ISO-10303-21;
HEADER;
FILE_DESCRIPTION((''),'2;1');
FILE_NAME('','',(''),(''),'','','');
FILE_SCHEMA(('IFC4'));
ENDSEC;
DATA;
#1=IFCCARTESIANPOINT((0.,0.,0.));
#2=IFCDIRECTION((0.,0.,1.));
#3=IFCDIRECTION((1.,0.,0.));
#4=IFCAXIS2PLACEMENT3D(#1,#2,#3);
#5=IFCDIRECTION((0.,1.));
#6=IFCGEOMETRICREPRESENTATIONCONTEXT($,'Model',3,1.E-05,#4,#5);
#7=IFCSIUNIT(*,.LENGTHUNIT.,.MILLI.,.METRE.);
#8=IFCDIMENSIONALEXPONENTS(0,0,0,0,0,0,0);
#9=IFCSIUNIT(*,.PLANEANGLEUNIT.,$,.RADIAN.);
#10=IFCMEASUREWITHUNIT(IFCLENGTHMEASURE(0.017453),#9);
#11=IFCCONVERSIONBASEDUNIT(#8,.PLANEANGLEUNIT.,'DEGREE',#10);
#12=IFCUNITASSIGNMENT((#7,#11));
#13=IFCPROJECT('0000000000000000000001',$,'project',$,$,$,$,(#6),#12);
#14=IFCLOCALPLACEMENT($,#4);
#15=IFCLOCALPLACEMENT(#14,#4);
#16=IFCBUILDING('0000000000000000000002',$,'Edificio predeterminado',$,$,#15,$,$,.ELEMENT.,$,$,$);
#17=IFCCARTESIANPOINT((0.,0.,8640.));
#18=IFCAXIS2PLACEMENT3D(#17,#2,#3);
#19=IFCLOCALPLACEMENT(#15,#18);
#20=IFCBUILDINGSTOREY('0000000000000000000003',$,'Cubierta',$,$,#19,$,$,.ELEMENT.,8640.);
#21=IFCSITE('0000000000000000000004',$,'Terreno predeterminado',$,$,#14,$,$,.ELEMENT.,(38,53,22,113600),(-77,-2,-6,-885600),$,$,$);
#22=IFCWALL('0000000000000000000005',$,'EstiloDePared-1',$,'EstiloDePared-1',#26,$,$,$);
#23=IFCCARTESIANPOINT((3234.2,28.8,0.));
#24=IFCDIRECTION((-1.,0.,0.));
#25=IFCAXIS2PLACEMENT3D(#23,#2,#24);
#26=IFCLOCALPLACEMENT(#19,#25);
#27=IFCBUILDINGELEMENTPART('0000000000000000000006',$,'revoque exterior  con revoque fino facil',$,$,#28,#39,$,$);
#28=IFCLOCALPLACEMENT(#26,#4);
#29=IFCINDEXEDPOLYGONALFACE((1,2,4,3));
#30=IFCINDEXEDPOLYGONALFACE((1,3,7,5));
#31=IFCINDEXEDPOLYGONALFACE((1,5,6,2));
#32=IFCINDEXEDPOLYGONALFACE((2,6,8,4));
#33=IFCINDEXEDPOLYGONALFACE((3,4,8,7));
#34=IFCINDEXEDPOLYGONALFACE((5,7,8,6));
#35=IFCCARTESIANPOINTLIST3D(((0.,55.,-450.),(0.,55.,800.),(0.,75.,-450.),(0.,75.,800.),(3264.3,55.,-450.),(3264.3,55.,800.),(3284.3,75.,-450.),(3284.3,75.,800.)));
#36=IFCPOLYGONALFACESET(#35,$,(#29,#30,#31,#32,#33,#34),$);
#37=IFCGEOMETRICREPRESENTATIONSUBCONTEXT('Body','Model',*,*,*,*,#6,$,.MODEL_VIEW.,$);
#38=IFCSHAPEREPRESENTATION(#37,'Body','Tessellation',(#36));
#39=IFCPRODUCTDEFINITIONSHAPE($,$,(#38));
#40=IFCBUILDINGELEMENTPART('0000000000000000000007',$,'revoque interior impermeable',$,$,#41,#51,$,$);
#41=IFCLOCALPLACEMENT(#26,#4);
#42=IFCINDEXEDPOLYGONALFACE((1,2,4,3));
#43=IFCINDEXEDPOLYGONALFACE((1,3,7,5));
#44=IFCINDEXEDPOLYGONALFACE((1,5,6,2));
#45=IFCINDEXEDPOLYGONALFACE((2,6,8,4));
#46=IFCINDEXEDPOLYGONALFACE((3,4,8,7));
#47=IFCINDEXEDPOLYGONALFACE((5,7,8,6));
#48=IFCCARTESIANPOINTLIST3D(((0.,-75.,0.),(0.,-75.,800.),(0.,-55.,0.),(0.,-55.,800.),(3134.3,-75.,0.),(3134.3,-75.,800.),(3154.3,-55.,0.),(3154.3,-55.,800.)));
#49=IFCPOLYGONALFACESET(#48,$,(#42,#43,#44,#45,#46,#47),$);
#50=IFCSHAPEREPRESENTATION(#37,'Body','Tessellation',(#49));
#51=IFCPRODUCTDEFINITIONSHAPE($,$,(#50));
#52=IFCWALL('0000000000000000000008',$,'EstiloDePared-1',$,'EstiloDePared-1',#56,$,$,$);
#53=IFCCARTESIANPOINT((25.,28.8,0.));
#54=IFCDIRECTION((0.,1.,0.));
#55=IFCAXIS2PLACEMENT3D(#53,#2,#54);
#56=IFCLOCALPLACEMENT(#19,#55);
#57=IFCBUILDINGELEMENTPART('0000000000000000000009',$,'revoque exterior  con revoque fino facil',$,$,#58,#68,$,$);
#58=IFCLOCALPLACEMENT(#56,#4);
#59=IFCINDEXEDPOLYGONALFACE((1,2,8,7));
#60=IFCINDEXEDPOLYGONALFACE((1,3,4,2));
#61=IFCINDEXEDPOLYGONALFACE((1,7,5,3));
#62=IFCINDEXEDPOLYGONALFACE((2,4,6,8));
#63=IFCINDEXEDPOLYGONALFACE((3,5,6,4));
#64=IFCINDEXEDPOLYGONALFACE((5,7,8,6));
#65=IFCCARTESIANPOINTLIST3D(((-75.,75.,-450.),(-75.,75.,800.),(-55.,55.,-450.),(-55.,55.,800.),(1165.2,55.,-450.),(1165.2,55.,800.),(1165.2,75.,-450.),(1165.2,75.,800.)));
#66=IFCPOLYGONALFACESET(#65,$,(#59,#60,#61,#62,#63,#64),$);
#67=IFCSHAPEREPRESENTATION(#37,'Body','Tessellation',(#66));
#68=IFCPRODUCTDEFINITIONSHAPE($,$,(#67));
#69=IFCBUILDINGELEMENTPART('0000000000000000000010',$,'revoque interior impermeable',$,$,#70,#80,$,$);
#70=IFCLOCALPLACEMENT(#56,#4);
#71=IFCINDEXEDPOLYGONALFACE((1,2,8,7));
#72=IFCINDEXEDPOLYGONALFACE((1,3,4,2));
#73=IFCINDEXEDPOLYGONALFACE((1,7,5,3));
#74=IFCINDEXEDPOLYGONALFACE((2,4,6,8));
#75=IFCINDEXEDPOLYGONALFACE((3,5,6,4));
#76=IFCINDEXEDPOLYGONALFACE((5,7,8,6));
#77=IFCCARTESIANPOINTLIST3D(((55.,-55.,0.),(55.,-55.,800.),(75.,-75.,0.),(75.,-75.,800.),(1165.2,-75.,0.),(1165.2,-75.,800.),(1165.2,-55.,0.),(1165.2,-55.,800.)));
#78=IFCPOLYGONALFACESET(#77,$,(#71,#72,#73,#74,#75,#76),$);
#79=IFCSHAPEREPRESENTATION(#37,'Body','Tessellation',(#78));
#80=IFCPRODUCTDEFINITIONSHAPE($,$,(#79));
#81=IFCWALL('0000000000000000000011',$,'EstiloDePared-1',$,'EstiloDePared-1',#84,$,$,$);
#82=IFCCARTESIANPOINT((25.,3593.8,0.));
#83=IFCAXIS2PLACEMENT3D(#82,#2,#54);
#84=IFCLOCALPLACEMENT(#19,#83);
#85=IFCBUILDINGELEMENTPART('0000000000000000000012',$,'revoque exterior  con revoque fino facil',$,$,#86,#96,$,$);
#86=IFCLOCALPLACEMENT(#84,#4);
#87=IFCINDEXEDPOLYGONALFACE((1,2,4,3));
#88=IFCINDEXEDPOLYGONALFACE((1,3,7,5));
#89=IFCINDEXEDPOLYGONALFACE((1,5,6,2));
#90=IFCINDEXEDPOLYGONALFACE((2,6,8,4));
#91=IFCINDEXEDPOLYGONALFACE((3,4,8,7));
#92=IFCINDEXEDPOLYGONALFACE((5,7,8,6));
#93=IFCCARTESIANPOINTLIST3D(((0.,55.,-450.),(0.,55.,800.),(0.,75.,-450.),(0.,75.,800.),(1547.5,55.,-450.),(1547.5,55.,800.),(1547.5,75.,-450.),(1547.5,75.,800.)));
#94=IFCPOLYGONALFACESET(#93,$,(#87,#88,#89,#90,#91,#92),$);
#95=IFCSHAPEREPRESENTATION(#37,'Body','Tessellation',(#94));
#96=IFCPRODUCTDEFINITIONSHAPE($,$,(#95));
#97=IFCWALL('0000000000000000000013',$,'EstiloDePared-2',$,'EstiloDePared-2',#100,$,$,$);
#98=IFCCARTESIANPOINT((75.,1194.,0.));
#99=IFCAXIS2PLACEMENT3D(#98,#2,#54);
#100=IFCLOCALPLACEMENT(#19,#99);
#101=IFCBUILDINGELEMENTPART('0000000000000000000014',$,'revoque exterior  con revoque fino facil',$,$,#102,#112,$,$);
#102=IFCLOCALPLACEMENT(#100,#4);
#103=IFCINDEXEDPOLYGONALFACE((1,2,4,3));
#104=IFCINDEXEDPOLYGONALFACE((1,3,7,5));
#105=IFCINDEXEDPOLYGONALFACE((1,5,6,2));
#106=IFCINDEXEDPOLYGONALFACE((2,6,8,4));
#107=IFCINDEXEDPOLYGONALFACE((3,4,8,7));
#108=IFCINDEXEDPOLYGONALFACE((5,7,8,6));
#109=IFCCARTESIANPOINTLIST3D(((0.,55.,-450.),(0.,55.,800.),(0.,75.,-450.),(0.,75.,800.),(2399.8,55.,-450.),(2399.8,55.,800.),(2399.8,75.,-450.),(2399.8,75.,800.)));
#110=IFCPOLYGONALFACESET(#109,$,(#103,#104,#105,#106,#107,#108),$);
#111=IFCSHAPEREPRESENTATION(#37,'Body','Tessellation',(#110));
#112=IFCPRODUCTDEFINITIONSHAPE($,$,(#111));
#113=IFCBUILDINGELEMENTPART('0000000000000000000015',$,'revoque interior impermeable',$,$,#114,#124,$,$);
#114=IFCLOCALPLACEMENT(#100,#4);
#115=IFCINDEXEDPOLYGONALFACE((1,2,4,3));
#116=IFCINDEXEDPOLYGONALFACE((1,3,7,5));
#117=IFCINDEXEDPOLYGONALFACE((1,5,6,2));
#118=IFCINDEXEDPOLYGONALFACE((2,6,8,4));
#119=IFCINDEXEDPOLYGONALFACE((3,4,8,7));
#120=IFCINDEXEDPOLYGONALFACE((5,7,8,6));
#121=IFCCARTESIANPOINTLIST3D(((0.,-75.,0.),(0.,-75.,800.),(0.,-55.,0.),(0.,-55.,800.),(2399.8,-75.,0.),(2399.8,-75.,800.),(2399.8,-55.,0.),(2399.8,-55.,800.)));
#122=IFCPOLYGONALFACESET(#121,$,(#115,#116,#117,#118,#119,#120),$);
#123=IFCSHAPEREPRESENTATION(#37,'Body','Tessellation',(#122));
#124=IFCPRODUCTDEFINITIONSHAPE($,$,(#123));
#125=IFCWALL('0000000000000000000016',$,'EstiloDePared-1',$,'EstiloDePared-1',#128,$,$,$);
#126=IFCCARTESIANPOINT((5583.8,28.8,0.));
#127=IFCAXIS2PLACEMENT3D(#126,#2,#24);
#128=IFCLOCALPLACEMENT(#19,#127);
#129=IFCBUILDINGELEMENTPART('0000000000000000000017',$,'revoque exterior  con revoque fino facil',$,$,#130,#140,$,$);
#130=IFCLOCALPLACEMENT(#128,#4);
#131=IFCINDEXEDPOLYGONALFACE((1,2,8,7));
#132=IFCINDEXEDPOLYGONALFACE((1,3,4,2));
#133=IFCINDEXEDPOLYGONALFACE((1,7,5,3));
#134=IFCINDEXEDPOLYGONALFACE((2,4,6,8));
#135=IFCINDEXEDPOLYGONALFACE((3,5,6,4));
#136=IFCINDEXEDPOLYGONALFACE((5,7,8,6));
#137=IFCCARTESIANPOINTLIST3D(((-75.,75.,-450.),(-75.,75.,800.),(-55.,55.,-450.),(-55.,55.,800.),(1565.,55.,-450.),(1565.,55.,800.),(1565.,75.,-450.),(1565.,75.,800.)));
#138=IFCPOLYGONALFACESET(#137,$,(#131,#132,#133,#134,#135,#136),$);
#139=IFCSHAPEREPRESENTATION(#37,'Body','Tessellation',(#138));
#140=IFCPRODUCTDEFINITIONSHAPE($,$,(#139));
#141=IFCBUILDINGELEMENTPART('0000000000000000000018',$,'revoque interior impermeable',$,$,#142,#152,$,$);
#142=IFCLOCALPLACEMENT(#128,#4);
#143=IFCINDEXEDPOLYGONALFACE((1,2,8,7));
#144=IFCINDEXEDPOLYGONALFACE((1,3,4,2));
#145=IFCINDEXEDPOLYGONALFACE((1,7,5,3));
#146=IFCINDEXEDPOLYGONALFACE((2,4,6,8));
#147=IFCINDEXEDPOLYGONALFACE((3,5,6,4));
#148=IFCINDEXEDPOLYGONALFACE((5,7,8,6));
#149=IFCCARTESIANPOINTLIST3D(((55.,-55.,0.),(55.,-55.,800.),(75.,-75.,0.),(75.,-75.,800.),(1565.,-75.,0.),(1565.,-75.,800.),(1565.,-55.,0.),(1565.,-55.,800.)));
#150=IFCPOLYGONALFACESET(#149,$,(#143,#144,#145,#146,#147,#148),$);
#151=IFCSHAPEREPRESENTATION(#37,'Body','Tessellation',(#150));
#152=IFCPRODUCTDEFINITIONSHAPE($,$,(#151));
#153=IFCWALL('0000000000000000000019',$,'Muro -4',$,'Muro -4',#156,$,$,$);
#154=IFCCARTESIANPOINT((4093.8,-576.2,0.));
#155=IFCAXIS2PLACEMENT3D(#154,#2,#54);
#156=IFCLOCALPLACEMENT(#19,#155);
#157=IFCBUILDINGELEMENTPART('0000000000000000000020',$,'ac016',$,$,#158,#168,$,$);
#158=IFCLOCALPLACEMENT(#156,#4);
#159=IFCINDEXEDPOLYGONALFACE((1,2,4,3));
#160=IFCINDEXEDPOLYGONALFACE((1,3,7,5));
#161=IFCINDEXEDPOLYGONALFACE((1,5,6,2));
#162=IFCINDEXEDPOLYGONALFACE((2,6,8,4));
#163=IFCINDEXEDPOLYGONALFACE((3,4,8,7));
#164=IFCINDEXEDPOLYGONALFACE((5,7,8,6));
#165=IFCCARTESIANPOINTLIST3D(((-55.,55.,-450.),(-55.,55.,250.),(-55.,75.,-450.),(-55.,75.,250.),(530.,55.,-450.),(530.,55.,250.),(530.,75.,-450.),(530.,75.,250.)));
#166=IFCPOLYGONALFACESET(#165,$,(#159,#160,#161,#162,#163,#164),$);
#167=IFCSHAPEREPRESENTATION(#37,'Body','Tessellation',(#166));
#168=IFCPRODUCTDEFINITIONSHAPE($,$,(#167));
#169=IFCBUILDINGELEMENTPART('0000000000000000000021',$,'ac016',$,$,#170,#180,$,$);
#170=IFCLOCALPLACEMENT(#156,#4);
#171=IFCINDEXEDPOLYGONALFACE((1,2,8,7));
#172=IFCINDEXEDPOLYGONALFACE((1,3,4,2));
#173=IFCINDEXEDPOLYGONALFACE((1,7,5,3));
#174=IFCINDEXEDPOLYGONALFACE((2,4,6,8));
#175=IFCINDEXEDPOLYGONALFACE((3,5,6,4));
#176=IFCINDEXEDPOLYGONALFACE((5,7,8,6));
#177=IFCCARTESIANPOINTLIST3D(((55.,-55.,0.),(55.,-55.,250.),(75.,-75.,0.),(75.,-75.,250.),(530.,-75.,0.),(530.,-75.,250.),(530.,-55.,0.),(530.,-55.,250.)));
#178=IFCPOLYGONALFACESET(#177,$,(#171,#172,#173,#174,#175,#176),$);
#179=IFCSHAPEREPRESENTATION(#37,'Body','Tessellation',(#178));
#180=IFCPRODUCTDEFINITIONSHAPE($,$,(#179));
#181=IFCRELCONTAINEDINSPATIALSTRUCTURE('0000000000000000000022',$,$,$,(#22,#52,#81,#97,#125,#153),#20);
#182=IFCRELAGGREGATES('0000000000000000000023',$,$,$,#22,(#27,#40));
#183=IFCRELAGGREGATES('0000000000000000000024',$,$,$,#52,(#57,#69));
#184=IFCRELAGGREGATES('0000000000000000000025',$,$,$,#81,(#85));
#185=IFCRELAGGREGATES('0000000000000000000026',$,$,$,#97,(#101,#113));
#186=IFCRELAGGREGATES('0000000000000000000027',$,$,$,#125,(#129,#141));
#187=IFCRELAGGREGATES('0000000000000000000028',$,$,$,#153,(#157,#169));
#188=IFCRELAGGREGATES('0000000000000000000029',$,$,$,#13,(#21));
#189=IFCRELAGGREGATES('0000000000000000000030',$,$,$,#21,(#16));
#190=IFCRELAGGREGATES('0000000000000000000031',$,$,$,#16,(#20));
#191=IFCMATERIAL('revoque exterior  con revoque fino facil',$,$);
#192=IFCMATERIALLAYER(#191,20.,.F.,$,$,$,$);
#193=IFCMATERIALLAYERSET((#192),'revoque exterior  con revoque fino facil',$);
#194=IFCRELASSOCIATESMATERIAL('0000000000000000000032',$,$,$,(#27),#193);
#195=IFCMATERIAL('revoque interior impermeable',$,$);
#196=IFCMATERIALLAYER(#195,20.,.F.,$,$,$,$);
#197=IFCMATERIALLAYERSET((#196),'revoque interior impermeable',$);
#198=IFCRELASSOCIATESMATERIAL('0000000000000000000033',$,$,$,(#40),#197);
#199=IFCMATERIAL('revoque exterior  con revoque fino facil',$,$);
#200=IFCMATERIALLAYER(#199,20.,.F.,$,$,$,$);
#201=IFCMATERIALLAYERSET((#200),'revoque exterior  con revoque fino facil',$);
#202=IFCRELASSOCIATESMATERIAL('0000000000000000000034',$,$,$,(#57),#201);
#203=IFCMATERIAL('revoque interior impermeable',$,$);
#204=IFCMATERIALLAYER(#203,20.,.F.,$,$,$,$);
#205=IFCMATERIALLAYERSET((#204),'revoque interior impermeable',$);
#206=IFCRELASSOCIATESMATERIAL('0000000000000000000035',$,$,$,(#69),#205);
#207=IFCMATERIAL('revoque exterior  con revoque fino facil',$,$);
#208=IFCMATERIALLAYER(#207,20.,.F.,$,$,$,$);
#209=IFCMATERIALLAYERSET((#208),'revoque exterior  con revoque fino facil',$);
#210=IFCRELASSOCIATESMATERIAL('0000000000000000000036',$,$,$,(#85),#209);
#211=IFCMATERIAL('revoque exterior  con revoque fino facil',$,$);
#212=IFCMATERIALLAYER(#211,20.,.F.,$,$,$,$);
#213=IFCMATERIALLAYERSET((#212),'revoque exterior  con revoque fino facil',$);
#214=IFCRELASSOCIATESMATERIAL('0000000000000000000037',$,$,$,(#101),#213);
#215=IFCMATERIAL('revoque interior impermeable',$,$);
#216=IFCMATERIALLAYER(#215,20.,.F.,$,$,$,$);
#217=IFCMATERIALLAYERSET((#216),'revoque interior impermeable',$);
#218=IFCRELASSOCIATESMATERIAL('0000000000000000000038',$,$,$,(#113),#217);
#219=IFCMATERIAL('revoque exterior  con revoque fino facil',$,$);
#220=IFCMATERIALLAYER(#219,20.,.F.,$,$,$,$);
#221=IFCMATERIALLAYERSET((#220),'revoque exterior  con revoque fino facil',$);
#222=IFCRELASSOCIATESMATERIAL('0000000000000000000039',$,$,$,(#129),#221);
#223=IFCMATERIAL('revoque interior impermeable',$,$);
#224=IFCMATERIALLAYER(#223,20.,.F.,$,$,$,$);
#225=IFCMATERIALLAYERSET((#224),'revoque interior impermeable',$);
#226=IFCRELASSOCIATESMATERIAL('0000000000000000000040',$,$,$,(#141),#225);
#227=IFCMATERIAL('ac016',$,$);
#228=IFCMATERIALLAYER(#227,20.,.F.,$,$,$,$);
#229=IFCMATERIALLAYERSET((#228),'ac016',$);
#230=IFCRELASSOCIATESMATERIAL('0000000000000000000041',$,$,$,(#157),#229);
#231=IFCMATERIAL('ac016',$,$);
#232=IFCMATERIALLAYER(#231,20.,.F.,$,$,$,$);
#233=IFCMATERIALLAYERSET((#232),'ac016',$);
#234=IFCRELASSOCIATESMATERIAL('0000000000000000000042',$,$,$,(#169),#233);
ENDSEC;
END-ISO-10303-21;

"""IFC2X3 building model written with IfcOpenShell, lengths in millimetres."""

from ifc_helpers import new_model, entity, si_unit, converted_unit, direction, frame, origin_with_axes, place, context, subcontext, project, spatial, polyline, outline, extrude, material, layer, layer_set, layer_usage, element, aggregate, save


model = new_model("IFC2X3")

# Units and contexts
model_context = context("Model", 3, precision=1e-05, world=origin_with_axes(), true_north=direction((0.0, 1.0)))
body_context = subcontext(model_context, "Body", "Model", "MODEL_VIEW")
ifc_project = project(units=[si_unit("LENGTHUNIT", "METRE", prefix="MILLI"), converted_unit("PLANEANGLEUNIT", "DEGREE", entity("IfcLengthMeasure", 0.017453), si_unit("PLANEANGLEUNIT", "RADIAN"), dimensions=[0, 0, 0, 0, 0, 0, 0])], contexts=[model_context])

# Site, building, storey
site_placement = place(None, origin_with_axes())
site = spatial("IfcSite", under=ifc_project, at=site_placement, Name="Terreno predeterminado", CompositionType="ELEMENT", RefLatitude=(38, 53, 22, 113600), RefLongitude=(-77, -2, -6, -885600))
building_placement = place(site_placement, origin_with_axes())
building = spatial("IfcBuilding", under=site, at=building_placement, Name="Edificio predeterminado", CompositionType="ELEMENT")
storey_placement = place(building_placement, frame((0.0, 0.0, 8640.0), z_axis=(0.0, 0.0, 1.0), x_axis=(1.0, 0.0, 0.0)))
storey = spatial("IfcBuildingStorey", under=building, at=storey_placement, Name="Cubierta", CompositionType="ELEMENT", Elevation=8640.0)

# Walls, building element parts
wall_1_placement = place(storey_placement, frame((3234.2, 28.8, 0.0), z_axis=(0.0, 0.0, 1.0), x_axis=(-1.0, 0.0, 0.0)))
wall_1 = element("IfcWall", 1, at=wall_1_placement, inside=storey, Name="EstiloDePared-1", ObjectType="EstiloDePared-1")
ifc_material_1 = material(Name="revoque exterior  con revoque fino facil")
ifc_layer_1 = layer(ifc_material_1, 20.0, ventilated=False)
ifc_layer_set_1 = layer_set([ifc_layer_1], Name="revoque exterior  con revoque fino facil")
ifc_layer_usage_1 = layer_usage(ifc_layer_set_1, "AXIS2", "NEGATIVE", -75.0)
building_element_part_1_placement = place(wall_1_placement, origin_with_axes())
building_element_part_1 = element("IfcBuildingElementPart", 2, at=building_element_part_1_placement, material=ifc_layer_usage_1, Name="revoque exterior  con revoque fino facil", context=body_context, shape_type="SweptSolid", body=[
    extrude(outline(polyline([(3284.2, 75.0), (3264.2, 55.0), (0.0, 55.0), (0.0, 75.0), (3284.2, 75.0)])), frame((0.0, 0.0, -450.0), z_axis=(0.0, 0.0, 1.0), x_axis=(1.0, 0.0, 0.0)), (0.0, 0.0, 1.0), 1250.0),
])
ifc_material_2 = material(Name="revoque interior impermeable")
ifc_layer_2 = layer(ifc_material_2, 20.0, ventilated=False)
ifc_layer_set_2 = layer_set([ifc_layer_2], Name="revoque interior impermeable")
ifc_layer_usage_2 = layer_usage(ifc_layer_set_2, "AXIS2", "NEGATIVE", 55.0)
building_element_part_2_placement = place(wall_1_placement, origin_with_axes())
building_element_part_2 = element("IfcBuildingElementPart", 3, at=building_element_part_2_placement, material=ifc_layer_usage_2, Name="revoque interior impermeable", context=body_context, shape_type="SweptSolid", body=[
    extrude(outline(polyline([(3154.2, -55.0), (3134.2, -75.0), (0.0, -75.0), (0.0, -55.0), (3154.2, -55.0)])), origin_with_axes(), (0.0, 0.0, 1.0), 800.0),
])
aggregate(wall_1, [building_element_part_1, building_element_part_2])
wall_2_placement = place(storey_placement, frame((25.0, 28.8, 0.0), z_axis=(0.0, 0.0, 1.0), x_axis=(0.0, 1.0, 0.0)))
wall_2 = element("IfcWall", 4, at=wall_2_placement, inside=storey, Name="EstiloDePared-1", ObjectType="EstiloDePared-1")
ifc_material_3 = material(Name="revoque exterior  con revoque fino facil")
ifc_layer_3 = layer(ifc_material_3, 20.0, ventilated=False)
ifc_layer_set_3 = layer_set([ifc_layer_3], Name="revoque exterior  con revoque fino facil")
ifc_layer_usage_3 = layer_usage(ifc_layer_set_3, "AXIS2", "NEGATIVE", -75.0)
building_element_part_3_placement = place(wall_2_placement, origin_with_axes())
building_element_part_3 = element("IfcBuildingElementPart", 5, at=building_element_part_3_placement, material=ifc_layer_usage_3, Name="revoque exterior  con revoque fino facil", context=body_context, shape_type="SweptSolid", body=[
    extrude(outline(polyline([(1165.2, 75.0), (1165.2, 55.0), (-55.0, 55.0), (-75.0, 75.0), (1165.2, 75.0)])), frame((0.0, 0.0, -450.0), z_axis=(0.0, 0.0, 1.0), x_axis=(1.0, 0.0, 0.0)), (0.0, 0.0, 1.0), 1250.0),
])
ifc_material_4 = material(Name="revoque interior impermeable")
ifc_layer_4 = layer(ifc_material_4, 20.0, ventilated=False)
ifc_layer_set_4 = layer_set([ifc_layer_4], Name="revoque interior impermeable")
ifc_layer_usage_4 = layer_usage(ifc_layer_set_4, "AXIS2", "NEGATIVE", 55.0)
building_element_part_4_placement = place(wall_2_placement, origin_with_axes())
building_element_part_4 = element("IfcBuildingElementPart", 6, at=building_element_part_4_placement, material=ifc_layer_usage_4, Name="revoque interior impermeable", context=body_context, shape_type="SweptSolid", body=[
    extrude(outline(polyline([(1165.2, -55.0), (1165.2, -75.0), (75.0, -75.0), (55.0, -55.0), (1165.2, -55.0)])), origin_with_axes(), (0.0, 0.0, 1.0), 800.0),
])
aggregate(wall_2, [building_element_part_3, building_element_part_4])
wall_3_placement = place(storey_placement, frame((25.0, 3593.8, 0.0), z_axis=(0.0, 0.0, 1.0), x_axis=(0.0, 1.0, 0.0)))
wall_3 = element("IfcWall", 7, at=wall_3_placement, inside=storey, Name="EstiloDePared-1", ObjectType="EstiloDePared-1")
ifc_material_5 = material(Name="revoque exterior  con revoque fino facil")
ifc_layer_5 = layer(ifc_material_5, 20.0, ventilated=False)
ifc_layer_set_5 = layer_set([ifc_layer_5], Name="revoque exterior  con revoque fino facil")
ifc_layer_usage_5 = layer_usage(ifc_layer_set_5, "AXIS2", "NEGATIVE", -75.0)
building_element_part_5_placement = place(wall_3_placement, origin_with_axes())
building_element_part_5 = element("IfcBuildingElementPart", 8, at=building_element_part_5_placement, material=ifc_layer_usage_5, Name="revoque exterior  con revoque fino facil", context=body_context, shape_type="SweptSolid", body=[
    extrude(outline(polyline([(1547.5, 75.0), (1547.5, 55.0), (0.0, 55.0), (0.0, 75.0), (1547.5, 75.0)])), frame((0.0, 0.0, -450.0), z_axis=(0.0, 0.0, 1.0), x_axis=(1.0, 0.0, 0.0)), (0.0, 0.0, 1.0), 1250.0),
])
aggregate(wall_3, [building_element_part_5])
wall_4_placement = place(storey_placement, frame((75.0, 1194.0, 0.0), z_axis=(0.0, 0.0, 1.0), x_axis=(0.0, 1.0, 0.0)))
wall_4 = element("IfcWall", 9, at=wall_4_placement, inside=storey, Name="EstiloDePared-2", ObjectType="EstiloDePared-2")
ifc_material_6 = material(Name="revoque exterior  con revoque fino facil")
ifc_layer_6 = layer(ifc_material_6, 20.0, ventilated=False)
ifc_layer_set_6 = layer_set([ifc_layer_6], Name="revoque exterior  con revoque fino facil")
ifc_layer_usage_6 = layer_usage(ifc_layer_set_6, "AXIS2", "NEGATIVE", -75.0)
building_element_part_6_placement = place(wall_4_placement, origin_with_axes())
building_element_part_6 = element("IfcBuildingElementPart", 10, at=building_element_part_6_placement, material=ifc_layer_usage_6, Name="revoque exterior  con revoque fino facil", context=body_context, shape_type="SweptSolid", body=[
    extrude(outline(polyline([(2399.8, 75.0), (2399.8, 55.0), (0.0, 55.0), (0.0, 75.0), (2399.8, 75.0)])), frame((0.0, 0.0, -450.0), z_axis=(0.0, 0.0, 1.0), x_axis=(1.0, 0.0, 0.0)), (0.0, 0.0, 1.0), 1250.0),
])
ifc_material_7 = material(Name="revoque interior impermeable")
ifc_layer_7 = layer(ifc_material_7, 20.0, ventilated=False)
ifc_layer_set_7 = layer_set([ifc_layer_7], Name="revoque interior impermeable")
ifc_layer_usage_7 = layer_usage(ifc_layer_set_7, "AXIS2", "NEGATIVE", 55.0)
building_element_part_7_placement = place(wall_4_placement, origin_with_axes())
building_element_part_7 = element("IfcBuildingElementPart", 11, at=building_element_part_7_placement, material=ifc_layer_usage_7, Name="revoque interior impermeable", context=body_context, shape_type="SweptSolid", body=[
    extrude(outline(polyline([(2399.8, -55.0), (2399.8, -75.0), (0.0, -75.0), (0.0, -55.0), (2399.8, -55.0)])), origin_with_axes(), (0.0, 0.0, 1.0), 800.0),
])
aggregate(wall_4, [building_element_part_6, building_element_part_7])
wall_5_placement = place(storey_placement, frame((5583.8, 28.8, 0.0), z_axis=(0.0, 0.0, 1.0), x_axis=(-1.0, 0.0, 0.0)))
wall_5 = element("IfcWall", 12, at=wall_5_placement, inside=storey, Name="EstiloDePared-1", ObjectType="EstiloDePared-1")
ifc_material_8 = material(Name="revoque exterior  con revoque fino facil")
ifc_layer_8 = layer(ifc_material_8, 20.0, ventilated=False)
ifc_layer_set_8 = layer_set([ifc_layer_8], Name="revoque exterior  con revoque fino facil")
ifc_layer_usage_8 = layer_usage(ifc_layer_set_8, "AXIS2", "NEGATIVE", -75.0)
building_element_part_8_placement = place(wall_5_placement, origin_with_axes())
building_element_part_8 = element("IfcBuildingElementPart", 13, at=building_element_part_8_placement, material=ifc_layer_usage_8, Name="revoque exterior  con revoque fino facil", context=body_context, shape_type="SweptSolid", body=[
    extrude(outline(polyline([(1565.0, 75.0), (1565.0, 55.0), (-55.0, 55.0), (-75.0, 75.0), (1565.0, 75.0)])), frame((0.0, 0.0, -450.0), z_axis=(0.0, 0.0, 1.0), x_axis=(1.0, 0.0, 0.0)), (0.0, 0.0, 1.0), 1250.0),
])
ifc_material_9 = material(Name="revoque interior impermeable")
ifc_layer_9 = layer(ifc_material_9, 20.0, ventilated=False)
ifc_layer_set_9 = layer_set([ifc_layer_9], Name="revoque interior impermeable")
ifc_layer_usage_9 = layer_usage(ifc_layer_set_9, "AXIS2", "NEGATIVE", 55.0)
building_element_part_9_placement = place(wall_5_placement, origin_with_axes())
building_element_part_9 = element("IfcBuildingElementPart", 14, at=building_element_part_9_placement, material=ifc_layer_usage_9, Name="revoque interior impermeable", context=body_context, shape_type="SweptSolid", body=[
    extrude(outline(polyline([(1565.0, -55.0), (1565.0, -75.0), (75.0, -75.0), (55.0, -55.0), (1565.0, -55.0)])), origin_with_axes(), (0.0, 0.0, 1.0), 800.0),
])
aggregate(wall_5, [building_element_part_8, building_element_part_9])
wall_6_placement = place(storey_placement, frame((4093.8, -576.2, 0.0), z_axis=(0.0, 0.0, 1.0), x_axis=(0.0, 1.0, 0.0)))
wall_6 = element("IfcWall", 15, at=wall_6_placement, inside=storey, Name="Muro -4", ObjectType="Muro -4")
ifc_material_10 = material(Name="ac016")
ifc_layer_10 = layer(ifc_material_10, 20.0, ventilated=False)
ifc_layer_set_10 = layer_set([ifc_layer_10], Name="ac016")
ifc_layer_usage_10 = layer_usage(ifc_layer_set_10, "AXIS2", "NEGATIVE", -75.0)
building_element_part_10_placement = place(wall_6_placement, origin_with_axes())
building_element_part_10 = element("IfcBuildingElementPart", 16, at=building_element_part_10_placement, material=ifc_layer_usage_10, Name="ac016", context=body_context, shape_type="SweptSolid", body=[
    extrude(outline(polyline([(530.0, 75.0), (530.0, 55.0), (-55.0, 55.0), (-55.0, 75.0), (530.0, 75.0)])), frame((0.0, 0.0, -450.0), z_axis=(0.0, 0.0, 1.0), x_axis=(1.0, 0.0, 0.0)), (0.0, 0.0, 1.0), 700.0),
])
ifc_material_11 = material(Name="ac016")
ifc_layer_11 = layer(ifc_material_11, 20.0, ventilated=False)
ifc_layer_set_11 = layer_set([ifc_layer_11], Name="ac016")
ifc_layer_usage_11 = layer_usage(ifc_layer_set_11, "AXIS2", "NEGATIVE", 55.0)
building_element_part_11_placement = place(wall_6_placement, origin_with_axes())
building_element_part_11 = element("IfcBuildingElementPart", 17, at=building_element_part_11_placement, material=ifc_layer_usage_11, Name="ac016", context=body_context, shape_type="SweptSolid", body=[
    extrude(outline(polyline([(530.0, -55.0), (530.0, -75.0), (75.0, -75.0), (55.0, -55.0), (530.0, -55.0)])), origin_with_axes(), (0.0, 0.0, 1.0), 250.0),
])
aggregate(wall_6, [building_element_part_10, building_element_part_11])

save(model, "model.ifc")
